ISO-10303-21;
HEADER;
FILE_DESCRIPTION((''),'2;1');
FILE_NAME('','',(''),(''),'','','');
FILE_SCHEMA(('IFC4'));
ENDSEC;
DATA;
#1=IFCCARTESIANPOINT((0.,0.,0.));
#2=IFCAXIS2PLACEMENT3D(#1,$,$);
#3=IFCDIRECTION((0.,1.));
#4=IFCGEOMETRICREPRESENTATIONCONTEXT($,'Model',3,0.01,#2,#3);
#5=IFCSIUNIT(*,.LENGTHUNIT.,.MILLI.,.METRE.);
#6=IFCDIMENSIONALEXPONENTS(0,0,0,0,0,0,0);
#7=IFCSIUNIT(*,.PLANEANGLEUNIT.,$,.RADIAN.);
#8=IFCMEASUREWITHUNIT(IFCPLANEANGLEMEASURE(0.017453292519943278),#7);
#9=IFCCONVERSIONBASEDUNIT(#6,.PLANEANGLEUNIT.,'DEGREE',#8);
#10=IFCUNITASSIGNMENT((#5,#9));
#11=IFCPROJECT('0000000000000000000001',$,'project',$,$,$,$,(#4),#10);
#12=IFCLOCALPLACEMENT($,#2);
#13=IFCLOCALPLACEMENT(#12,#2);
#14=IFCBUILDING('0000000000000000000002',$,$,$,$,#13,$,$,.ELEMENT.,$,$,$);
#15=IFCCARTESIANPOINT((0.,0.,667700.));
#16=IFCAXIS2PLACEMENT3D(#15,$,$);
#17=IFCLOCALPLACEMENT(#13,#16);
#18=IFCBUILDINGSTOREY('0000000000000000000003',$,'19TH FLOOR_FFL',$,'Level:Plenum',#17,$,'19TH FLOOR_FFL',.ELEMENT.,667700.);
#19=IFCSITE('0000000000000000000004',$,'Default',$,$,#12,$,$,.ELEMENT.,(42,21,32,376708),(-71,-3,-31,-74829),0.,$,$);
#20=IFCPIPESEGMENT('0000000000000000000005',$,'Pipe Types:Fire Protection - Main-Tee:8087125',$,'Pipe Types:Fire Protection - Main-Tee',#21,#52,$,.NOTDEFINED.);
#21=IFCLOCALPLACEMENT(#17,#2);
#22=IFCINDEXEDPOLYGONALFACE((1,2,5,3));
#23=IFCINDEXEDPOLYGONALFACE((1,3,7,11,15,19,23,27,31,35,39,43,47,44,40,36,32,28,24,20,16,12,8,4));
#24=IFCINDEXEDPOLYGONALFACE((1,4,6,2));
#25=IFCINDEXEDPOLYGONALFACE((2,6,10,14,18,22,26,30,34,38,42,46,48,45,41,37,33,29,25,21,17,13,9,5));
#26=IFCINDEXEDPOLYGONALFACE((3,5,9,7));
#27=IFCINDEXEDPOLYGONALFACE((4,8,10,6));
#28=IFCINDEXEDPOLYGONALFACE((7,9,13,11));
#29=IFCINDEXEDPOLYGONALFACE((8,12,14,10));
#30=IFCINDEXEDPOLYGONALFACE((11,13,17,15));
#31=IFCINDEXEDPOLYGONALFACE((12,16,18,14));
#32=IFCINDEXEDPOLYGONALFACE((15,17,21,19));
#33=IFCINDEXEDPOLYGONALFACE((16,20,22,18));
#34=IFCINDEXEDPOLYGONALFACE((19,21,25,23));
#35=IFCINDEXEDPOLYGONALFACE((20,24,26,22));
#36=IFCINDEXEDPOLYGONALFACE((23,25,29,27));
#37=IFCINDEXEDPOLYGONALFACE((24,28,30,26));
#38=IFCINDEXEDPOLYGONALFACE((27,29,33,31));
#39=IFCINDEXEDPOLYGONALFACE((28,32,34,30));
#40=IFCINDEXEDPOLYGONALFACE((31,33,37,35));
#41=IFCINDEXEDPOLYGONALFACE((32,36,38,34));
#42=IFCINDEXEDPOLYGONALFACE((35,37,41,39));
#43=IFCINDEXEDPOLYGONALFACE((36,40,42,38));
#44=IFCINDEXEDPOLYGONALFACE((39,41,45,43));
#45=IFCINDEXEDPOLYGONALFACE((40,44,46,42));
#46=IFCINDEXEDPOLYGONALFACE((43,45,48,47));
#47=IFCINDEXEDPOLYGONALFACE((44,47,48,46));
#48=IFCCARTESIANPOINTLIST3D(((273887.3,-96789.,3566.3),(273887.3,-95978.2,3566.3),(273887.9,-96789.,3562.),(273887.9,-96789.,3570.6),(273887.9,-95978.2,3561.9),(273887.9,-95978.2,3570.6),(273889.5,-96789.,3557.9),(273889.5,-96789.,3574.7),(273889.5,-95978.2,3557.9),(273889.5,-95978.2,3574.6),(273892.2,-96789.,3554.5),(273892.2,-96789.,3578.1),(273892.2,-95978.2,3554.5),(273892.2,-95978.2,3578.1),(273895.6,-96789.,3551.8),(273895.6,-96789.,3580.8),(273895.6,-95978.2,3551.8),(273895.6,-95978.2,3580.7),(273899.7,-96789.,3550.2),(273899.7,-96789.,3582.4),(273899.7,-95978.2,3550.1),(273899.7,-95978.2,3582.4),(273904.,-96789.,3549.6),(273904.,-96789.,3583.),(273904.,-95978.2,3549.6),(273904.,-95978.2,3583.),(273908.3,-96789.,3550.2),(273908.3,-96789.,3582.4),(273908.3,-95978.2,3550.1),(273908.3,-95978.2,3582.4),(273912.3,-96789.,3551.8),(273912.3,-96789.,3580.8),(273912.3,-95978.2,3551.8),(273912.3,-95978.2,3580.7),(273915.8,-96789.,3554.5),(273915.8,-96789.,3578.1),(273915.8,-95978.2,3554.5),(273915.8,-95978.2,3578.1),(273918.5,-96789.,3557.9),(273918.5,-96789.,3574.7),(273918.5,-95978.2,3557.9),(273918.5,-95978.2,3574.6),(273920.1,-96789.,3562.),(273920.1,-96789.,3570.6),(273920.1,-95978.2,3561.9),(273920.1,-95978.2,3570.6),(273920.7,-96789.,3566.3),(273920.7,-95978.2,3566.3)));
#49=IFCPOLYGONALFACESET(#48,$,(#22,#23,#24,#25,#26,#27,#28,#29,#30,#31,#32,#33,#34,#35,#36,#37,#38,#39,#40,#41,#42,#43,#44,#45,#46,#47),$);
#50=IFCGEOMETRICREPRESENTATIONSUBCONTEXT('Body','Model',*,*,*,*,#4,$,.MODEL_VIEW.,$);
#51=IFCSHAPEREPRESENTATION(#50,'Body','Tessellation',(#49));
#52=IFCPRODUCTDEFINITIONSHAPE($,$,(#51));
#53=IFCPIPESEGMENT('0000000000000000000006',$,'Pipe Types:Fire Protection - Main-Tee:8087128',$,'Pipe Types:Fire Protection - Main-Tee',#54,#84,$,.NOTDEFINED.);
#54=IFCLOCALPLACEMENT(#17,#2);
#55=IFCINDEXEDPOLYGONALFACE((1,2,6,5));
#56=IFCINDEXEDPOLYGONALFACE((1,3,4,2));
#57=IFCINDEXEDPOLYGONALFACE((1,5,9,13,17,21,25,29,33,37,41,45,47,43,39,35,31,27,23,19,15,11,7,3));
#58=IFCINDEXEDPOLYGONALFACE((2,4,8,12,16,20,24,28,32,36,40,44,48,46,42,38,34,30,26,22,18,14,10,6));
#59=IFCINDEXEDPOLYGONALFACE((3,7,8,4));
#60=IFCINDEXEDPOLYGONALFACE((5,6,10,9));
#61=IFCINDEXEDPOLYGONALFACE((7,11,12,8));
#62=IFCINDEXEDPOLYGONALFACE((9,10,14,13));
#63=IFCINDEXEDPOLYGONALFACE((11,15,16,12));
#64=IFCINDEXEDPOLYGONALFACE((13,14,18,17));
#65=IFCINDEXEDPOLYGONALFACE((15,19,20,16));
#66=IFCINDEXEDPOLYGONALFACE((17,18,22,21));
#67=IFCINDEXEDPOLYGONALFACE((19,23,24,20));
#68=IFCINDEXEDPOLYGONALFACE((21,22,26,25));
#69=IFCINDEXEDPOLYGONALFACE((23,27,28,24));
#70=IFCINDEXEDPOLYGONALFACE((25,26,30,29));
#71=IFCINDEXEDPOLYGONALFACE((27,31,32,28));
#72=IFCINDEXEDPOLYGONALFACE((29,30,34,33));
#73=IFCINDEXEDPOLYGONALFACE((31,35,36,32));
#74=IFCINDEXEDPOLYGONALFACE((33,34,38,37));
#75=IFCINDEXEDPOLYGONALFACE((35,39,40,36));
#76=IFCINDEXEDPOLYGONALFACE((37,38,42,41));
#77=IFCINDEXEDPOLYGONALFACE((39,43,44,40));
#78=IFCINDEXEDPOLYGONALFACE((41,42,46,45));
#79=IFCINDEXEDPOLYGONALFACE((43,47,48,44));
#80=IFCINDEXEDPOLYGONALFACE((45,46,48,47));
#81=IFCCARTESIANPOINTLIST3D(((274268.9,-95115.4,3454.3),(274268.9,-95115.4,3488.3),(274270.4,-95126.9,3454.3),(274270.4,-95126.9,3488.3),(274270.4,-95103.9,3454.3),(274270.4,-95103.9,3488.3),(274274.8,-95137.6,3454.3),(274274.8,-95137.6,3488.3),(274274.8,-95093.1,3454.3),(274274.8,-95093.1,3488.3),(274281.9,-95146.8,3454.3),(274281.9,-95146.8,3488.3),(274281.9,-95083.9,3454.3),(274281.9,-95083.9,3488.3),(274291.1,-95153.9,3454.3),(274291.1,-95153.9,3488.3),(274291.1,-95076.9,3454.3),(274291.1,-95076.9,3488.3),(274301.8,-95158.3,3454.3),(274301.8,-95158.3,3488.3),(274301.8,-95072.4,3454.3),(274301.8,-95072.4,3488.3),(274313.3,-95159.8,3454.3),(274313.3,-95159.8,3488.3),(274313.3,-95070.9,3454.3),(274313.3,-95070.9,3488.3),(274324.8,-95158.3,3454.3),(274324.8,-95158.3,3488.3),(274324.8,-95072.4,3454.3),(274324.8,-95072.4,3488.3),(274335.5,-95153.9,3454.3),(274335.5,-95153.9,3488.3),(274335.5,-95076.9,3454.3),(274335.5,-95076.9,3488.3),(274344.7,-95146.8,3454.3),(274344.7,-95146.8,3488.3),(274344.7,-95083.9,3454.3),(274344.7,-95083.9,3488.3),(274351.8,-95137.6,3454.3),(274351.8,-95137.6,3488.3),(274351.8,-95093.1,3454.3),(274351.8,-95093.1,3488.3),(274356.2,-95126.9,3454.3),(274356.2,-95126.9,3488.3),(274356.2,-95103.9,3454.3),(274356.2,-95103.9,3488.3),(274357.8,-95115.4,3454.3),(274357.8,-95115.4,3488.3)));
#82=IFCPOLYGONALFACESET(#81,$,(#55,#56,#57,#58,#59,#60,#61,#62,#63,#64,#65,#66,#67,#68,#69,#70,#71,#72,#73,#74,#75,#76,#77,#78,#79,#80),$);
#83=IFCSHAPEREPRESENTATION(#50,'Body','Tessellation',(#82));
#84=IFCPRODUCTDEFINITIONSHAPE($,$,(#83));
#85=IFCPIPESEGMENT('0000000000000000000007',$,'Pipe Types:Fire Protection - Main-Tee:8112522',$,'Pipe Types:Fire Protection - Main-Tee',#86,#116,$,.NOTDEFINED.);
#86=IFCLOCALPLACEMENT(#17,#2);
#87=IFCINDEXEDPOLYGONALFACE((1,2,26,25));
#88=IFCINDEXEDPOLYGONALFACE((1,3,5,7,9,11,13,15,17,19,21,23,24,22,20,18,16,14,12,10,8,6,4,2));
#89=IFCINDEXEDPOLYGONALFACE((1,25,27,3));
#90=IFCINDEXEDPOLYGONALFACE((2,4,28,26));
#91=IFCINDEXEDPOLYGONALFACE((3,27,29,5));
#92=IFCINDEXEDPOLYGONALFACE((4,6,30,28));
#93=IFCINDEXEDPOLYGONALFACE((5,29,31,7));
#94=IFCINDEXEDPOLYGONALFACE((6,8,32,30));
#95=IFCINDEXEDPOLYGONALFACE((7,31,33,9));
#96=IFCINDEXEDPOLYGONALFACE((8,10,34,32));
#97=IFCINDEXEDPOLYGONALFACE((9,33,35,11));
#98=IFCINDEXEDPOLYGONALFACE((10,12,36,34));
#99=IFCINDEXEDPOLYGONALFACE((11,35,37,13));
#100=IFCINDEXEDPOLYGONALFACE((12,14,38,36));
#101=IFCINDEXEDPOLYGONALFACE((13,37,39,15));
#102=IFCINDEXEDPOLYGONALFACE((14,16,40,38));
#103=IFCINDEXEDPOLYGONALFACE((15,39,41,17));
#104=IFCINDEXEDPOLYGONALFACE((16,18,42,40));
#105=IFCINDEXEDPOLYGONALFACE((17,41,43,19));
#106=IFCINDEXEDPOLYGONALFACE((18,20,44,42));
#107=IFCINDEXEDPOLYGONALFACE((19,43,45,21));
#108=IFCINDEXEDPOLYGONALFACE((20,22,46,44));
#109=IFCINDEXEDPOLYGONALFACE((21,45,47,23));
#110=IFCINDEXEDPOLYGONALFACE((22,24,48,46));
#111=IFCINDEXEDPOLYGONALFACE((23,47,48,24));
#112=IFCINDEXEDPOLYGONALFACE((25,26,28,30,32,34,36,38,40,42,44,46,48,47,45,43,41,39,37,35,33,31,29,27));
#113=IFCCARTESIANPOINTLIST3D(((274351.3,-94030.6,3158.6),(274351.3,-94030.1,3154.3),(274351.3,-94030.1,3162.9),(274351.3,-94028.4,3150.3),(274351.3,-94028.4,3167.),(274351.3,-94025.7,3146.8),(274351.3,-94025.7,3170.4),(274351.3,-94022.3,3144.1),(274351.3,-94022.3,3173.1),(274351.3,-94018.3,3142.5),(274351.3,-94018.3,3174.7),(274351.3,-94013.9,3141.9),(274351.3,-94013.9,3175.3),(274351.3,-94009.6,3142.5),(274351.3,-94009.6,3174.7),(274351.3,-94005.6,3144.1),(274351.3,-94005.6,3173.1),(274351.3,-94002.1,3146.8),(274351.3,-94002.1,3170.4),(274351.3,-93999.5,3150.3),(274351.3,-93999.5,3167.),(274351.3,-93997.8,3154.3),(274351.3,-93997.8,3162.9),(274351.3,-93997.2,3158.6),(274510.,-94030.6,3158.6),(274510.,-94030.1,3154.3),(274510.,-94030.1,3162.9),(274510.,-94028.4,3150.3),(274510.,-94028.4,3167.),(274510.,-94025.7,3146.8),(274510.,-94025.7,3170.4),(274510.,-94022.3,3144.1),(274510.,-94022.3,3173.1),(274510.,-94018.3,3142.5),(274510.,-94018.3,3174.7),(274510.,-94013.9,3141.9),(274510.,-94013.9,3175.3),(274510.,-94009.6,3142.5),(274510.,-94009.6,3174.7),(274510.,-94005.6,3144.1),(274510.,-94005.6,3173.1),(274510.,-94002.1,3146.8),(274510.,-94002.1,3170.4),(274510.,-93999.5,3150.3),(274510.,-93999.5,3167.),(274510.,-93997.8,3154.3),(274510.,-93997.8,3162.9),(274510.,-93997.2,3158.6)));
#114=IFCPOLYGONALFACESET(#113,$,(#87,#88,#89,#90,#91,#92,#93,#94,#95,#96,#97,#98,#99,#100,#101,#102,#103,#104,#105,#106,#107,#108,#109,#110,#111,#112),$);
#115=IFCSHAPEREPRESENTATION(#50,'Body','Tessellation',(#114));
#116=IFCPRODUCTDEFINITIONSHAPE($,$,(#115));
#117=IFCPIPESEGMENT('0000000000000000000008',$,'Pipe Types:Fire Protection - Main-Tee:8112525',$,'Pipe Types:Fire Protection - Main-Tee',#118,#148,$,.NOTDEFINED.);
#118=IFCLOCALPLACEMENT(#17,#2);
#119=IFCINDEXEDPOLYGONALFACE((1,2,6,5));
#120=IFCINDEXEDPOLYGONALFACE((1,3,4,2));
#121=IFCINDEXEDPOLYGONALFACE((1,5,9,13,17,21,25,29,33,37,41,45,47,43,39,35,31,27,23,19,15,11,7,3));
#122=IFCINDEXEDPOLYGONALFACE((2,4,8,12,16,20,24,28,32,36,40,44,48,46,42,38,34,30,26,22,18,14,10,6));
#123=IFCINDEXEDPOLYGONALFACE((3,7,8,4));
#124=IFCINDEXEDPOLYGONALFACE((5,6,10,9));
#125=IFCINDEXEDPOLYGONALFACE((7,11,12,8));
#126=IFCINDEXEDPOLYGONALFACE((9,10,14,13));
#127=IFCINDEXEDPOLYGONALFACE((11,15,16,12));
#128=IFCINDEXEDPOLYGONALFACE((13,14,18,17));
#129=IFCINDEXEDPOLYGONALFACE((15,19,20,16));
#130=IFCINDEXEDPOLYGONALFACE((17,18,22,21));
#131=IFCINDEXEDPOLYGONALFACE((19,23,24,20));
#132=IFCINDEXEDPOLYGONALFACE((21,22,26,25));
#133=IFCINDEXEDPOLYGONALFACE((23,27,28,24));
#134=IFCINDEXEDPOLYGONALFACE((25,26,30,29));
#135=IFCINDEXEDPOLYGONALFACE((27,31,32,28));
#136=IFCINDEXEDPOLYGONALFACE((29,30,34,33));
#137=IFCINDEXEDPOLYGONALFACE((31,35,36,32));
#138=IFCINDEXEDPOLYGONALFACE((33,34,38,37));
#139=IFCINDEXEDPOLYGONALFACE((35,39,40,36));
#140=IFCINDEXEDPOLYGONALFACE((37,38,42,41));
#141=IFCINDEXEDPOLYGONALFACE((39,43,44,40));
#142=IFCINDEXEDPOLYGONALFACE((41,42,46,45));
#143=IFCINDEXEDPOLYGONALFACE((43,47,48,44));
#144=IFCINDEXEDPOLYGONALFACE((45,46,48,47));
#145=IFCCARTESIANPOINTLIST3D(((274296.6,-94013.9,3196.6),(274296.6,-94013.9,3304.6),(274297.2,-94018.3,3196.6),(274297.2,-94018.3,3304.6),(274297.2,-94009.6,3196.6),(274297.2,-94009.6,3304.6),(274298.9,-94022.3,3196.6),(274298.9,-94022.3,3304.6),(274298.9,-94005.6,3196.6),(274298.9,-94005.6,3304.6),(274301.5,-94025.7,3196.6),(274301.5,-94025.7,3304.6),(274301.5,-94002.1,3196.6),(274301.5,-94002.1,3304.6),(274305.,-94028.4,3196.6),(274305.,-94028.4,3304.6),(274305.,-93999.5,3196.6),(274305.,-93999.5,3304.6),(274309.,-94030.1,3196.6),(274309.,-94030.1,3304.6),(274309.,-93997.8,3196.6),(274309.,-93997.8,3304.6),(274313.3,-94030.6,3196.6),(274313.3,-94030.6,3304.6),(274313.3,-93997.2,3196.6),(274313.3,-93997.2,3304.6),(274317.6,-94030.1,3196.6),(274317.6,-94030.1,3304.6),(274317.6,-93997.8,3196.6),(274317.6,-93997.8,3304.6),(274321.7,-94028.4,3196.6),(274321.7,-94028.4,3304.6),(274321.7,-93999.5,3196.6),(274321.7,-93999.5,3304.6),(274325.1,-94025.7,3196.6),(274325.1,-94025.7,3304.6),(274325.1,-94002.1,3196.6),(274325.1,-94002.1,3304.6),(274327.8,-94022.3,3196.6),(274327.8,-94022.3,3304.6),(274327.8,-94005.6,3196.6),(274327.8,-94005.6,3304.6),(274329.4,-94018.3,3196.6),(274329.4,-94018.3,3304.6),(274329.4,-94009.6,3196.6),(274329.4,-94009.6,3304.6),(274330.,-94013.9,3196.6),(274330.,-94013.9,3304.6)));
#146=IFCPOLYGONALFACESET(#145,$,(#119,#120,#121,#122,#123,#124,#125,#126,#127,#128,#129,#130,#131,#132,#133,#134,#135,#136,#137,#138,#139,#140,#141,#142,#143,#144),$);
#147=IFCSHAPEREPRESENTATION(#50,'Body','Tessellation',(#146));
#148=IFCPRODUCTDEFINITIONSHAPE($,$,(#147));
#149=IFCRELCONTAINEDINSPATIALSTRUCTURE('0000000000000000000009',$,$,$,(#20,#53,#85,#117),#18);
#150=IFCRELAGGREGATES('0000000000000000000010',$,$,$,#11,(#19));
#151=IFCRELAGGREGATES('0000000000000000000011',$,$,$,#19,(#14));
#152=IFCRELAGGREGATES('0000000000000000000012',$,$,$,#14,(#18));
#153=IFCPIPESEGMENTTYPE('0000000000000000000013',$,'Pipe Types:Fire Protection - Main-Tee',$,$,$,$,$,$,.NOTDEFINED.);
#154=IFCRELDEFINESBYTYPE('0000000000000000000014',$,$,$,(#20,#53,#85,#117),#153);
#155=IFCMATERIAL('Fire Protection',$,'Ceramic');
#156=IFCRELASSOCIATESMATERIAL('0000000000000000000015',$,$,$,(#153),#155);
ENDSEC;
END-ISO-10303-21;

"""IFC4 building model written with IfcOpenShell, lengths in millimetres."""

from ifc_helpers import new_model, entity, si_unit, converted_unit, direction, frame, origin, place, context, subcontext, project, spatial, arc, indexed_curve, outline, extrude, material, type_object, element, save


model = new_model("IFC4")

# Units and contexts
model_context = context("Model", 3, precision=0.01, world=origin(), true_north=direction((0.0, 1.0)))
body_context = subcontext(model_context, "Body", "Model", "MODEL_VIEW")
ifc_project = project(units=[si_unit("LENGTHUNIT", "METRE", prefix="MILLI"), converted_unit("PLANEANGLEUNIT", "DEGREE", entity("IfcPlaneAngleMeasure", 0.017453292519943278), si_unit("PLANEANGLEUNIT", "RADIAN"), dimensions=[0, 0, 0, 0, 0, 0, 0])], contexts=[model_context])

# Site, building, storey
site_placement = place(None, origin())
site = spatial("IfcSite", under=ifc_project, at=site_placement, Name="Default", CompositionType="ELEMENT", RefLatitude=(42, 21, 32, 376708), RefLongitude=(-71, -3, -31, -74829), RefElevation=0.0)
building_placement = place(site_placement, origin())
building = spatial("IfcBuilding", under=site, at=building_placement, CompositionType="ELEMENT")
storey_placement = place(building_placement, frame((0.0, 0.0, 667700.0)))
storey = spatial("IfcBuildingStorey", under=building, at=storey_placement, Name="19TH FLOOR_FFL", ObjectType="Level:Plenum", LongName="19TH FLOOR_FFL", CompositionType="ELEMENT", Elevation=667700.0)

# Pipe segments
ifc_material = material(Name="Fire Protection", Category="Ceramic")
pipe_segment_type = type_object("IfcPipeSegmentType", Name="Pipe Types:Fire Protection - Main-Tee", PredefinedType="NOTDEFINED", material=ifc_material)
pipe_segment_1_placement = place(storey_placement, origin())
element("IfcPipeSegment", 1, at=pipe_segment_1_placement, inside=storey, type_object=pipe_segment_type, Name="Pipe Types:Fire Protection - Main-Tee:8087125", ObjectType="Pipe Types:Fire Protection - Main-Tee", PredefinedType="NOTDEFINED", context=body_context, shape_type="SweptSolid", body=[
    extrude(outline(indexed_curve([(16.7, 0.0), (11.8, 11.8), (0.0, 16.7), (-11.8, 11.8), (-16.7, 0.0), (-11.8, -11.8), (0.0, -16.7), (11.8, -11.8)], segments=[arc(1, 2, 3), arc(3, 4, 5), arc(5, 6, 7), arc(7, 8, 1)], self_intersect=False)), frame((273904.0, -95978.2, 3566.3), z_axis=(0.0, -1.0, 0.000043), x_axis=(1.0, 0.0, 0.0)), (0.0, 0.0, 1.0), 810.8),
])
pipe_segment_2_placement = place(storey_placement, origin())
element("IfcPipeSegment", 2, at=pipe_segment_2_placement, inside=storey, type_object=pipe_segment_type, Name="Pipe Types:Fire Protection - Main-Tee:8087128", ObjectType="Pipe Types:Fire Protection - Main-Tee", PredefinedType="NOTDEFINED", context=body_context, shape_type="SweptSolid", body=[
    extrude(outline(indexed_curve([(44.5, 0.0), (31.4, 31.4), (0.0, 44.4), (-31.4, 31.4), (-44.4, 0.0), (-31.4, -31.4), (0.0, -44.5), (31.4, -31.4)], segments=[arc(1, 2, 3), arc(3, 4, 5), arc(5, 6, 7), arc(7, 8, 1)], self_intersect=False)), frame((274313.3, -95115.4, 3454.3)), (0.0, 0.0, 1.0), 34.0),
])
pipe_segment_3_placement = place(storey_placement, origin())
element("IfcPipeSegment", 3, at=pipe_segment_3_placement, inside=storey, type_object=pipe_segment_type, Name="Pipe Types:Fire Protection - Main-Tee:8112522", ObjectType="Pipe Types:Fire Protection - Main-Tee", PredefinedType="NOTDEFINED", context=body_context, shape_type="SweptSolid", body=[
    extrude(outline(indexed_curve([(16.7, 0.0), (11.8, 11.8), (0.0, 16.7), (-11.8, 11.8), (-16.7, 0.0), (-11.8, -11.8), (0.0, -16.7), (11.8, -11.8)], segments=[arc(1, 2, 3), arc(3, 4, 5), arc(5, 6, 7), arc(7, 8, 1)], self_intersect=False)), frame((274351.3, -94013.9, 3158.6), z_axis=(1.0, 0.0, 0.0), x_axis=(0.0, 1.0, 0.0)), (0.0, 0.0, 1.0), 158.7),
])
pipe_segment_4_placement = place(storey_placement, origin())
element("IfcPipeSegment", 4, at=pipe_segment_4_placement, inside=storey, type_object=pipe_segment_type, Name="Pipe Types:Fire Protection - Main-Tee:8112525", ObjectType="Pipe Types:Fire Protection - Main-Tee", PredefinedType="NOTDEFINED", context=body_context, shape_type="SweptSolid", body=[
    extrude(outline(indexed_curve([(16.7, 0.0), (11.8, 11.8), (0.0, 16.7), (-11.8, 11.8), (-16.7, 0.0), (-11.8, -11.8), (0.0, -16.7), (11.8, -11.8)], segments=[arc(1, 2, 3), arc(3, 4, 5), arc(5, 6, 7), arc(7, 8, 1)], self_intersect=False)), frame((274313.3, -94013.9, 3196.6)), (0.0, 0.0, 1.0), 108.0),
])

save(model, "model.ifc")
